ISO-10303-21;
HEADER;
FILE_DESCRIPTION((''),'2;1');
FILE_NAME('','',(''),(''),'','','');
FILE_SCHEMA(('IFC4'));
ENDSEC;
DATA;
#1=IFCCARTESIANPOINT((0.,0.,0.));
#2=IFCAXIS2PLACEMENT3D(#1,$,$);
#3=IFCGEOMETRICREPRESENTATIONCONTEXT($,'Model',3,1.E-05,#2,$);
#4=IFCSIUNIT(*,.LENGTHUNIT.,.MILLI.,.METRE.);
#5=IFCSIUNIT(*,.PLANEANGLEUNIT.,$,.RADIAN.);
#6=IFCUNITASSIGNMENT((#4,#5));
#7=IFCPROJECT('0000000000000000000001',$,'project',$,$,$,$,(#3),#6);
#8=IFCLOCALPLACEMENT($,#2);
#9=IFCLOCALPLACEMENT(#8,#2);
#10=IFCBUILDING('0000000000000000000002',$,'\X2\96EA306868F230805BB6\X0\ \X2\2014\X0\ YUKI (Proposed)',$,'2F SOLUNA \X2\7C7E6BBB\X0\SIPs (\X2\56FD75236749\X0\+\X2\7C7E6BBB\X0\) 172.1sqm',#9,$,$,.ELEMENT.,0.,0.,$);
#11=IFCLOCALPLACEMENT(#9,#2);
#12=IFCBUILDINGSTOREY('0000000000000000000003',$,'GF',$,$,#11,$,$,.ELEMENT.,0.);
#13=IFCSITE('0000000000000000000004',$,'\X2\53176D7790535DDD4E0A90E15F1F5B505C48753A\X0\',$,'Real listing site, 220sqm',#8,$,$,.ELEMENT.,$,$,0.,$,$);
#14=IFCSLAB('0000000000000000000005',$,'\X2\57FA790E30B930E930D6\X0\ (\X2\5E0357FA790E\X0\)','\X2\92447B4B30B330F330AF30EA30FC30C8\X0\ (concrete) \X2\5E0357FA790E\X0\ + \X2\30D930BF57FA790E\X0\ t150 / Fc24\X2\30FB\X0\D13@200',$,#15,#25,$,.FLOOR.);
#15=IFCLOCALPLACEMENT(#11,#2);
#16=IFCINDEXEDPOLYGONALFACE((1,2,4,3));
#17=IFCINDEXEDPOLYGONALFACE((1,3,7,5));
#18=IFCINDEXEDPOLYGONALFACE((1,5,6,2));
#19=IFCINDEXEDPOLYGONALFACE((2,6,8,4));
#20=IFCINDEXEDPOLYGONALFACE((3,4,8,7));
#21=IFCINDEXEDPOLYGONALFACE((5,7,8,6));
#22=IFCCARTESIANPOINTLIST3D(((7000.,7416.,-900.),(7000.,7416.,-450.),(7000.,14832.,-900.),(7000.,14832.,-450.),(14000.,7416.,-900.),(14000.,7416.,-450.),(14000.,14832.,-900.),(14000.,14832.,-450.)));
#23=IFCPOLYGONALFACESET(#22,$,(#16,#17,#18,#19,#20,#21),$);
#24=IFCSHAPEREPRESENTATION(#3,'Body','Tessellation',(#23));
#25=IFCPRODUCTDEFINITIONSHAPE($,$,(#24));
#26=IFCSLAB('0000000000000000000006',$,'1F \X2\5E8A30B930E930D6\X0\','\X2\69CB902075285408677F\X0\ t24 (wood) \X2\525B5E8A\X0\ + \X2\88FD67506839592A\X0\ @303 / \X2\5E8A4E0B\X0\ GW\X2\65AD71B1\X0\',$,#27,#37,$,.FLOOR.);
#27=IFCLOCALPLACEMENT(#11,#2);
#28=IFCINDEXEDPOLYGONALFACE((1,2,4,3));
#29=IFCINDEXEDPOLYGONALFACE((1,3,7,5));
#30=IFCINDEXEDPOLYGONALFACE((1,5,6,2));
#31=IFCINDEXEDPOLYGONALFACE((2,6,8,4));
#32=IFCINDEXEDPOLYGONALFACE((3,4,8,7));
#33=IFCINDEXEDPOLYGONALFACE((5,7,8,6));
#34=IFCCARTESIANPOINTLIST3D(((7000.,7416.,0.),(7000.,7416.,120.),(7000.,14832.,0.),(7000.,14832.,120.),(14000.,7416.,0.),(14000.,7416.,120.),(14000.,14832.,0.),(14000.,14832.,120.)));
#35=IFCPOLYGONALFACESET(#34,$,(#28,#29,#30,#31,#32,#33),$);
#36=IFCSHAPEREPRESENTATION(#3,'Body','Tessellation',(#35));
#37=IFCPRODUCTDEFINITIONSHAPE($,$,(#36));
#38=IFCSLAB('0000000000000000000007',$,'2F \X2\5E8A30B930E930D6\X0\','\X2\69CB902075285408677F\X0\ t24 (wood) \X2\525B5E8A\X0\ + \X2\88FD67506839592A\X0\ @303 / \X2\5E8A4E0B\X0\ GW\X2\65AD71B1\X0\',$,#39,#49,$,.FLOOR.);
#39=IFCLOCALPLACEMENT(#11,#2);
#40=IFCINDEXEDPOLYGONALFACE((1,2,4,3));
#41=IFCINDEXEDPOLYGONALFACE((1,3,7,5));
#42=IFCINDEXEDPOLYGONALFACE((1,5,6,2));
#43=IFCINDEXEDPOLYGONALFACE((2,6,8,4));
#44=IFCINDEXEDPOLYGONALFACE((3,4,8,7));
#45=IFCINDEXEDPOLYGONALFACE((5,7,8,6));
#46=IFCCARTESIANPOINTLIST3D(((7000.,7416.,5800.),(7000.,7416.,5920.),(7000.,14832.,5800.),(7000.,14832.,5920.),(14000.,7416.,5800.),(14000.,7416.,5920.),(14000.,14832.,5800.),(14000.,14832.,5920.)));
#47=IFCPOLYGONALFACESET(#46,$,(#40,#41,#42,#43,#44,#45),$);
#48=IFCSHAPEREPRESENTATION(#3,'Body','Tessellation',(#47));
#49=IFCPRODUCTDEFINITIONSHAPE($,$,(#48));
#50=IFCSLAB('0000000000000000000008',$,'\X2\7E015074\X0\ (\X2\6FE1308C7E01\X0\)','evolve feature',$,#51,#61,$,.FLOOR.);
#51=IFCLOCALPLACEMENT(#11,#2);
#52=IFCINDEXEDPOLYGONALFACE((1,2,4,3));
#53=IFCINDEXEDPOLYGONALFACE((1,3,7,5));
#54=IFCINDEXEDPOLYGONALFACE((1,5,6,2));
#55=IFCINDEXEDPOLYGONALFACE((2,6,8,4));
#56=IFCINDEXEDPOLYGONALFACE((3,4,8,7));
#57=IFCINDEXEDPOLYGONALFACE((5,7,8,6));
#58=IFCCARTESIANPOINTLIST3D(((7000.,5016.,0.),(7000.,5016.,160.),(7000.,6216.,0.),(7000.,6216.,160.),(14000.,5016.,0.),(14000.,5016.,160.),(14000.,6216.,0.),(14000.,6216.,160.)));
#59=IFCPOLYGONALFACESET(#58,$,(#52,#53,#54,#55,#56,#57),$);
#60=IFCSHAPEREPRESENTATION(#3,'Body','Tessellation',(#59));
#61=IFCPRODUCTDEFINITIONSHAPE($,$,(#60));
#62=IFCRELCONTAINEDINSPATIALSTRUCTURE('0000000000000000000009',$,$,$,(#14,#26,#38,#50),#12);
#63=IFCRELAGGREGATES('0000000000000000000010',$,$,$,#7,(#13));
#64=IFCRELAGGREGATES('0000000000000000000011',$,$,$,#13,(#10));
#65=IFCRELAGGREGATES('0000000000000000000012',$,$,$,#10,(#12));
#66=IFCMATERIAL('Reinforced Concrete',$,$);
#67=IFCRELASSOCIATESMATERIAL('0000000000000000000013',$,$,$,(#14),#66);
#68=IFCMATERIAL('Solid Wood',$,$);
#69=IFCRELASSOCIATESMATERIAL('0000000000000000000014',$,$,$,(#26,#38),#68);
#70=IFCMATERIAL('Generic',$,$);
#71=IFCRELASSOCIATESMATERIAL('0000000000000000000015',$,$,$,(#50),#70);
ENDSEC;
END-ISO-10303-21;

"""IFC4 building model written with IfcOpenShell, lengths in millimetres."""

from ifc_helpers import new_model, si_unit, frame, frame_2d, origin, place, context, project, spatial, rectangle, extrude, material, element, save


model = new_model("IFC4")

# Units and contexts
model_context = context("Model", 3, precision=1e-05, world=origin())
ifc_project = project(units=[si_unit("LENGTHUNIT", "METRE", prefix="MILLI"), si_unit("PLANEANGLEUNIT", "RADIAN")], contexts=[model_context])

# Site, building, storey
site_placement = place(None, origin())
site = spatial("IfcSite", under=ifc_project, at=site_placement, Name="北海道川上郡弟子屈町", ObjectType="Real listing site, 220sqm", CompositionType="ELEMENT", RefElevation=0.0)
building_placement = place(site_placement, origin())
building = spatial("IfcBuilding", under=site, at=building_placement, Name="雪と棲む家 — YUKI (Proposed)", ObjectType="2F SOLUNA 籾殻SIPs (国産杉+籾殻) 172.1sqm", CompositionType="ELEMENT", ElevationOfRefHeight=0.0, ElevationOfTerrain=0.0)
storey_placement = place(building_placement, origin())
storey = spatial("IfcBuildingStorey", under=building, at=storey_placement, Name="GF", CompositionType="ELEMENT", Elevation=0.0)

# Slabs
ifc_material_1 = material(Name="Reinforced Concrete")
slab_1_placement = place(storey_placement, frame((3500.0, 3708.0, -450.0)))
element("IfcSlab", 1, at=slab_1_placement, inside=storey, material=ifc_material_1, Name="基礎スラブ (布基礎)", Description="鉄筋コンクリート (concrete) 布基礎 + ベタ基礎 t150 / Fc24・D13@200", PredefinedType="FLOOR", context=model_context, shape_type="SweptSolid", body=[
    extrude(rectangle(XDim=7000.0, YDim=7416.0, at=frame_2d((3500.0, 3708.0))), frame((3500.0, 3708.0, -450.0)), (0.0, 0.0, 1.0), 450.0),
])
ifc_material_2 = material(Name="Solid Wood")
slab_2_placement = place(storey_placement, frame((3500.0, 3708.0, 0.0)))
element("IfcSlab", 2, at=slab_2_placement, inside=storey, material=ifc_material_2, Name="1F 床スラブ", Description="構造用合板 t24 (wood) 剛床 + 製材根太 @303 / 床下 GW断熱", PredefinedType="FLOOR", context=model_context, shape_type="SweptSolid", body=[
    extrude(rectangle(XDim=7000.0, YDim=7416.0, at=frame_2d((3500.0, 3708.0))), frame((3500.0, 3708.0, 0.0)), (0.0, 0.0, 1.0), 120.0),
])
slab_3_placement = place(storey_placement, frame((3500.0, 3708.0, 2900.0)))
element("IfcSlab", 3, at=slab_3_placement, inside=storey, material=ifc_material_2, Name="2F 床スラブ", Description="構造用合板 t24 (wood) 剛床 + 製材根太 @303 / 床下 GW断熱", PredefinedType="FLOOR", context=model_context, shape_type="SweptSolid", body=[
    extrude(rectangle(XDim=7000.0, YDim=7416.0, at=frame_2d((3500.0, 3708.0))), frame((3500.0, 3708.0, 2900.0)), (0.0, 0.0, 1.0), 120.0),
])
ifc_material_3 = material(Name="Generic")
slab_4_placement = place(storey_placement, frame((3500.0, 2508.0, 0.0)))
element("IfcSlab", 4, at=slab_4_placement, inside=storey, material=ifc_material_3, Name="縁側 (濡れ縁)", Description="evolve feature", PredefinedType="FLOOR", context=model_context, shape_type="SweptSolid", body=[
    extrude(rectangle(XDim=7000.0, YDim=1200.0, at=frame_2d((3500.0, 600.0))), frame((3500.0, 2508.0, 0.0)), (0.0, 0.0, 1.0), 160.0),
])

save(model, "model.ifc")
